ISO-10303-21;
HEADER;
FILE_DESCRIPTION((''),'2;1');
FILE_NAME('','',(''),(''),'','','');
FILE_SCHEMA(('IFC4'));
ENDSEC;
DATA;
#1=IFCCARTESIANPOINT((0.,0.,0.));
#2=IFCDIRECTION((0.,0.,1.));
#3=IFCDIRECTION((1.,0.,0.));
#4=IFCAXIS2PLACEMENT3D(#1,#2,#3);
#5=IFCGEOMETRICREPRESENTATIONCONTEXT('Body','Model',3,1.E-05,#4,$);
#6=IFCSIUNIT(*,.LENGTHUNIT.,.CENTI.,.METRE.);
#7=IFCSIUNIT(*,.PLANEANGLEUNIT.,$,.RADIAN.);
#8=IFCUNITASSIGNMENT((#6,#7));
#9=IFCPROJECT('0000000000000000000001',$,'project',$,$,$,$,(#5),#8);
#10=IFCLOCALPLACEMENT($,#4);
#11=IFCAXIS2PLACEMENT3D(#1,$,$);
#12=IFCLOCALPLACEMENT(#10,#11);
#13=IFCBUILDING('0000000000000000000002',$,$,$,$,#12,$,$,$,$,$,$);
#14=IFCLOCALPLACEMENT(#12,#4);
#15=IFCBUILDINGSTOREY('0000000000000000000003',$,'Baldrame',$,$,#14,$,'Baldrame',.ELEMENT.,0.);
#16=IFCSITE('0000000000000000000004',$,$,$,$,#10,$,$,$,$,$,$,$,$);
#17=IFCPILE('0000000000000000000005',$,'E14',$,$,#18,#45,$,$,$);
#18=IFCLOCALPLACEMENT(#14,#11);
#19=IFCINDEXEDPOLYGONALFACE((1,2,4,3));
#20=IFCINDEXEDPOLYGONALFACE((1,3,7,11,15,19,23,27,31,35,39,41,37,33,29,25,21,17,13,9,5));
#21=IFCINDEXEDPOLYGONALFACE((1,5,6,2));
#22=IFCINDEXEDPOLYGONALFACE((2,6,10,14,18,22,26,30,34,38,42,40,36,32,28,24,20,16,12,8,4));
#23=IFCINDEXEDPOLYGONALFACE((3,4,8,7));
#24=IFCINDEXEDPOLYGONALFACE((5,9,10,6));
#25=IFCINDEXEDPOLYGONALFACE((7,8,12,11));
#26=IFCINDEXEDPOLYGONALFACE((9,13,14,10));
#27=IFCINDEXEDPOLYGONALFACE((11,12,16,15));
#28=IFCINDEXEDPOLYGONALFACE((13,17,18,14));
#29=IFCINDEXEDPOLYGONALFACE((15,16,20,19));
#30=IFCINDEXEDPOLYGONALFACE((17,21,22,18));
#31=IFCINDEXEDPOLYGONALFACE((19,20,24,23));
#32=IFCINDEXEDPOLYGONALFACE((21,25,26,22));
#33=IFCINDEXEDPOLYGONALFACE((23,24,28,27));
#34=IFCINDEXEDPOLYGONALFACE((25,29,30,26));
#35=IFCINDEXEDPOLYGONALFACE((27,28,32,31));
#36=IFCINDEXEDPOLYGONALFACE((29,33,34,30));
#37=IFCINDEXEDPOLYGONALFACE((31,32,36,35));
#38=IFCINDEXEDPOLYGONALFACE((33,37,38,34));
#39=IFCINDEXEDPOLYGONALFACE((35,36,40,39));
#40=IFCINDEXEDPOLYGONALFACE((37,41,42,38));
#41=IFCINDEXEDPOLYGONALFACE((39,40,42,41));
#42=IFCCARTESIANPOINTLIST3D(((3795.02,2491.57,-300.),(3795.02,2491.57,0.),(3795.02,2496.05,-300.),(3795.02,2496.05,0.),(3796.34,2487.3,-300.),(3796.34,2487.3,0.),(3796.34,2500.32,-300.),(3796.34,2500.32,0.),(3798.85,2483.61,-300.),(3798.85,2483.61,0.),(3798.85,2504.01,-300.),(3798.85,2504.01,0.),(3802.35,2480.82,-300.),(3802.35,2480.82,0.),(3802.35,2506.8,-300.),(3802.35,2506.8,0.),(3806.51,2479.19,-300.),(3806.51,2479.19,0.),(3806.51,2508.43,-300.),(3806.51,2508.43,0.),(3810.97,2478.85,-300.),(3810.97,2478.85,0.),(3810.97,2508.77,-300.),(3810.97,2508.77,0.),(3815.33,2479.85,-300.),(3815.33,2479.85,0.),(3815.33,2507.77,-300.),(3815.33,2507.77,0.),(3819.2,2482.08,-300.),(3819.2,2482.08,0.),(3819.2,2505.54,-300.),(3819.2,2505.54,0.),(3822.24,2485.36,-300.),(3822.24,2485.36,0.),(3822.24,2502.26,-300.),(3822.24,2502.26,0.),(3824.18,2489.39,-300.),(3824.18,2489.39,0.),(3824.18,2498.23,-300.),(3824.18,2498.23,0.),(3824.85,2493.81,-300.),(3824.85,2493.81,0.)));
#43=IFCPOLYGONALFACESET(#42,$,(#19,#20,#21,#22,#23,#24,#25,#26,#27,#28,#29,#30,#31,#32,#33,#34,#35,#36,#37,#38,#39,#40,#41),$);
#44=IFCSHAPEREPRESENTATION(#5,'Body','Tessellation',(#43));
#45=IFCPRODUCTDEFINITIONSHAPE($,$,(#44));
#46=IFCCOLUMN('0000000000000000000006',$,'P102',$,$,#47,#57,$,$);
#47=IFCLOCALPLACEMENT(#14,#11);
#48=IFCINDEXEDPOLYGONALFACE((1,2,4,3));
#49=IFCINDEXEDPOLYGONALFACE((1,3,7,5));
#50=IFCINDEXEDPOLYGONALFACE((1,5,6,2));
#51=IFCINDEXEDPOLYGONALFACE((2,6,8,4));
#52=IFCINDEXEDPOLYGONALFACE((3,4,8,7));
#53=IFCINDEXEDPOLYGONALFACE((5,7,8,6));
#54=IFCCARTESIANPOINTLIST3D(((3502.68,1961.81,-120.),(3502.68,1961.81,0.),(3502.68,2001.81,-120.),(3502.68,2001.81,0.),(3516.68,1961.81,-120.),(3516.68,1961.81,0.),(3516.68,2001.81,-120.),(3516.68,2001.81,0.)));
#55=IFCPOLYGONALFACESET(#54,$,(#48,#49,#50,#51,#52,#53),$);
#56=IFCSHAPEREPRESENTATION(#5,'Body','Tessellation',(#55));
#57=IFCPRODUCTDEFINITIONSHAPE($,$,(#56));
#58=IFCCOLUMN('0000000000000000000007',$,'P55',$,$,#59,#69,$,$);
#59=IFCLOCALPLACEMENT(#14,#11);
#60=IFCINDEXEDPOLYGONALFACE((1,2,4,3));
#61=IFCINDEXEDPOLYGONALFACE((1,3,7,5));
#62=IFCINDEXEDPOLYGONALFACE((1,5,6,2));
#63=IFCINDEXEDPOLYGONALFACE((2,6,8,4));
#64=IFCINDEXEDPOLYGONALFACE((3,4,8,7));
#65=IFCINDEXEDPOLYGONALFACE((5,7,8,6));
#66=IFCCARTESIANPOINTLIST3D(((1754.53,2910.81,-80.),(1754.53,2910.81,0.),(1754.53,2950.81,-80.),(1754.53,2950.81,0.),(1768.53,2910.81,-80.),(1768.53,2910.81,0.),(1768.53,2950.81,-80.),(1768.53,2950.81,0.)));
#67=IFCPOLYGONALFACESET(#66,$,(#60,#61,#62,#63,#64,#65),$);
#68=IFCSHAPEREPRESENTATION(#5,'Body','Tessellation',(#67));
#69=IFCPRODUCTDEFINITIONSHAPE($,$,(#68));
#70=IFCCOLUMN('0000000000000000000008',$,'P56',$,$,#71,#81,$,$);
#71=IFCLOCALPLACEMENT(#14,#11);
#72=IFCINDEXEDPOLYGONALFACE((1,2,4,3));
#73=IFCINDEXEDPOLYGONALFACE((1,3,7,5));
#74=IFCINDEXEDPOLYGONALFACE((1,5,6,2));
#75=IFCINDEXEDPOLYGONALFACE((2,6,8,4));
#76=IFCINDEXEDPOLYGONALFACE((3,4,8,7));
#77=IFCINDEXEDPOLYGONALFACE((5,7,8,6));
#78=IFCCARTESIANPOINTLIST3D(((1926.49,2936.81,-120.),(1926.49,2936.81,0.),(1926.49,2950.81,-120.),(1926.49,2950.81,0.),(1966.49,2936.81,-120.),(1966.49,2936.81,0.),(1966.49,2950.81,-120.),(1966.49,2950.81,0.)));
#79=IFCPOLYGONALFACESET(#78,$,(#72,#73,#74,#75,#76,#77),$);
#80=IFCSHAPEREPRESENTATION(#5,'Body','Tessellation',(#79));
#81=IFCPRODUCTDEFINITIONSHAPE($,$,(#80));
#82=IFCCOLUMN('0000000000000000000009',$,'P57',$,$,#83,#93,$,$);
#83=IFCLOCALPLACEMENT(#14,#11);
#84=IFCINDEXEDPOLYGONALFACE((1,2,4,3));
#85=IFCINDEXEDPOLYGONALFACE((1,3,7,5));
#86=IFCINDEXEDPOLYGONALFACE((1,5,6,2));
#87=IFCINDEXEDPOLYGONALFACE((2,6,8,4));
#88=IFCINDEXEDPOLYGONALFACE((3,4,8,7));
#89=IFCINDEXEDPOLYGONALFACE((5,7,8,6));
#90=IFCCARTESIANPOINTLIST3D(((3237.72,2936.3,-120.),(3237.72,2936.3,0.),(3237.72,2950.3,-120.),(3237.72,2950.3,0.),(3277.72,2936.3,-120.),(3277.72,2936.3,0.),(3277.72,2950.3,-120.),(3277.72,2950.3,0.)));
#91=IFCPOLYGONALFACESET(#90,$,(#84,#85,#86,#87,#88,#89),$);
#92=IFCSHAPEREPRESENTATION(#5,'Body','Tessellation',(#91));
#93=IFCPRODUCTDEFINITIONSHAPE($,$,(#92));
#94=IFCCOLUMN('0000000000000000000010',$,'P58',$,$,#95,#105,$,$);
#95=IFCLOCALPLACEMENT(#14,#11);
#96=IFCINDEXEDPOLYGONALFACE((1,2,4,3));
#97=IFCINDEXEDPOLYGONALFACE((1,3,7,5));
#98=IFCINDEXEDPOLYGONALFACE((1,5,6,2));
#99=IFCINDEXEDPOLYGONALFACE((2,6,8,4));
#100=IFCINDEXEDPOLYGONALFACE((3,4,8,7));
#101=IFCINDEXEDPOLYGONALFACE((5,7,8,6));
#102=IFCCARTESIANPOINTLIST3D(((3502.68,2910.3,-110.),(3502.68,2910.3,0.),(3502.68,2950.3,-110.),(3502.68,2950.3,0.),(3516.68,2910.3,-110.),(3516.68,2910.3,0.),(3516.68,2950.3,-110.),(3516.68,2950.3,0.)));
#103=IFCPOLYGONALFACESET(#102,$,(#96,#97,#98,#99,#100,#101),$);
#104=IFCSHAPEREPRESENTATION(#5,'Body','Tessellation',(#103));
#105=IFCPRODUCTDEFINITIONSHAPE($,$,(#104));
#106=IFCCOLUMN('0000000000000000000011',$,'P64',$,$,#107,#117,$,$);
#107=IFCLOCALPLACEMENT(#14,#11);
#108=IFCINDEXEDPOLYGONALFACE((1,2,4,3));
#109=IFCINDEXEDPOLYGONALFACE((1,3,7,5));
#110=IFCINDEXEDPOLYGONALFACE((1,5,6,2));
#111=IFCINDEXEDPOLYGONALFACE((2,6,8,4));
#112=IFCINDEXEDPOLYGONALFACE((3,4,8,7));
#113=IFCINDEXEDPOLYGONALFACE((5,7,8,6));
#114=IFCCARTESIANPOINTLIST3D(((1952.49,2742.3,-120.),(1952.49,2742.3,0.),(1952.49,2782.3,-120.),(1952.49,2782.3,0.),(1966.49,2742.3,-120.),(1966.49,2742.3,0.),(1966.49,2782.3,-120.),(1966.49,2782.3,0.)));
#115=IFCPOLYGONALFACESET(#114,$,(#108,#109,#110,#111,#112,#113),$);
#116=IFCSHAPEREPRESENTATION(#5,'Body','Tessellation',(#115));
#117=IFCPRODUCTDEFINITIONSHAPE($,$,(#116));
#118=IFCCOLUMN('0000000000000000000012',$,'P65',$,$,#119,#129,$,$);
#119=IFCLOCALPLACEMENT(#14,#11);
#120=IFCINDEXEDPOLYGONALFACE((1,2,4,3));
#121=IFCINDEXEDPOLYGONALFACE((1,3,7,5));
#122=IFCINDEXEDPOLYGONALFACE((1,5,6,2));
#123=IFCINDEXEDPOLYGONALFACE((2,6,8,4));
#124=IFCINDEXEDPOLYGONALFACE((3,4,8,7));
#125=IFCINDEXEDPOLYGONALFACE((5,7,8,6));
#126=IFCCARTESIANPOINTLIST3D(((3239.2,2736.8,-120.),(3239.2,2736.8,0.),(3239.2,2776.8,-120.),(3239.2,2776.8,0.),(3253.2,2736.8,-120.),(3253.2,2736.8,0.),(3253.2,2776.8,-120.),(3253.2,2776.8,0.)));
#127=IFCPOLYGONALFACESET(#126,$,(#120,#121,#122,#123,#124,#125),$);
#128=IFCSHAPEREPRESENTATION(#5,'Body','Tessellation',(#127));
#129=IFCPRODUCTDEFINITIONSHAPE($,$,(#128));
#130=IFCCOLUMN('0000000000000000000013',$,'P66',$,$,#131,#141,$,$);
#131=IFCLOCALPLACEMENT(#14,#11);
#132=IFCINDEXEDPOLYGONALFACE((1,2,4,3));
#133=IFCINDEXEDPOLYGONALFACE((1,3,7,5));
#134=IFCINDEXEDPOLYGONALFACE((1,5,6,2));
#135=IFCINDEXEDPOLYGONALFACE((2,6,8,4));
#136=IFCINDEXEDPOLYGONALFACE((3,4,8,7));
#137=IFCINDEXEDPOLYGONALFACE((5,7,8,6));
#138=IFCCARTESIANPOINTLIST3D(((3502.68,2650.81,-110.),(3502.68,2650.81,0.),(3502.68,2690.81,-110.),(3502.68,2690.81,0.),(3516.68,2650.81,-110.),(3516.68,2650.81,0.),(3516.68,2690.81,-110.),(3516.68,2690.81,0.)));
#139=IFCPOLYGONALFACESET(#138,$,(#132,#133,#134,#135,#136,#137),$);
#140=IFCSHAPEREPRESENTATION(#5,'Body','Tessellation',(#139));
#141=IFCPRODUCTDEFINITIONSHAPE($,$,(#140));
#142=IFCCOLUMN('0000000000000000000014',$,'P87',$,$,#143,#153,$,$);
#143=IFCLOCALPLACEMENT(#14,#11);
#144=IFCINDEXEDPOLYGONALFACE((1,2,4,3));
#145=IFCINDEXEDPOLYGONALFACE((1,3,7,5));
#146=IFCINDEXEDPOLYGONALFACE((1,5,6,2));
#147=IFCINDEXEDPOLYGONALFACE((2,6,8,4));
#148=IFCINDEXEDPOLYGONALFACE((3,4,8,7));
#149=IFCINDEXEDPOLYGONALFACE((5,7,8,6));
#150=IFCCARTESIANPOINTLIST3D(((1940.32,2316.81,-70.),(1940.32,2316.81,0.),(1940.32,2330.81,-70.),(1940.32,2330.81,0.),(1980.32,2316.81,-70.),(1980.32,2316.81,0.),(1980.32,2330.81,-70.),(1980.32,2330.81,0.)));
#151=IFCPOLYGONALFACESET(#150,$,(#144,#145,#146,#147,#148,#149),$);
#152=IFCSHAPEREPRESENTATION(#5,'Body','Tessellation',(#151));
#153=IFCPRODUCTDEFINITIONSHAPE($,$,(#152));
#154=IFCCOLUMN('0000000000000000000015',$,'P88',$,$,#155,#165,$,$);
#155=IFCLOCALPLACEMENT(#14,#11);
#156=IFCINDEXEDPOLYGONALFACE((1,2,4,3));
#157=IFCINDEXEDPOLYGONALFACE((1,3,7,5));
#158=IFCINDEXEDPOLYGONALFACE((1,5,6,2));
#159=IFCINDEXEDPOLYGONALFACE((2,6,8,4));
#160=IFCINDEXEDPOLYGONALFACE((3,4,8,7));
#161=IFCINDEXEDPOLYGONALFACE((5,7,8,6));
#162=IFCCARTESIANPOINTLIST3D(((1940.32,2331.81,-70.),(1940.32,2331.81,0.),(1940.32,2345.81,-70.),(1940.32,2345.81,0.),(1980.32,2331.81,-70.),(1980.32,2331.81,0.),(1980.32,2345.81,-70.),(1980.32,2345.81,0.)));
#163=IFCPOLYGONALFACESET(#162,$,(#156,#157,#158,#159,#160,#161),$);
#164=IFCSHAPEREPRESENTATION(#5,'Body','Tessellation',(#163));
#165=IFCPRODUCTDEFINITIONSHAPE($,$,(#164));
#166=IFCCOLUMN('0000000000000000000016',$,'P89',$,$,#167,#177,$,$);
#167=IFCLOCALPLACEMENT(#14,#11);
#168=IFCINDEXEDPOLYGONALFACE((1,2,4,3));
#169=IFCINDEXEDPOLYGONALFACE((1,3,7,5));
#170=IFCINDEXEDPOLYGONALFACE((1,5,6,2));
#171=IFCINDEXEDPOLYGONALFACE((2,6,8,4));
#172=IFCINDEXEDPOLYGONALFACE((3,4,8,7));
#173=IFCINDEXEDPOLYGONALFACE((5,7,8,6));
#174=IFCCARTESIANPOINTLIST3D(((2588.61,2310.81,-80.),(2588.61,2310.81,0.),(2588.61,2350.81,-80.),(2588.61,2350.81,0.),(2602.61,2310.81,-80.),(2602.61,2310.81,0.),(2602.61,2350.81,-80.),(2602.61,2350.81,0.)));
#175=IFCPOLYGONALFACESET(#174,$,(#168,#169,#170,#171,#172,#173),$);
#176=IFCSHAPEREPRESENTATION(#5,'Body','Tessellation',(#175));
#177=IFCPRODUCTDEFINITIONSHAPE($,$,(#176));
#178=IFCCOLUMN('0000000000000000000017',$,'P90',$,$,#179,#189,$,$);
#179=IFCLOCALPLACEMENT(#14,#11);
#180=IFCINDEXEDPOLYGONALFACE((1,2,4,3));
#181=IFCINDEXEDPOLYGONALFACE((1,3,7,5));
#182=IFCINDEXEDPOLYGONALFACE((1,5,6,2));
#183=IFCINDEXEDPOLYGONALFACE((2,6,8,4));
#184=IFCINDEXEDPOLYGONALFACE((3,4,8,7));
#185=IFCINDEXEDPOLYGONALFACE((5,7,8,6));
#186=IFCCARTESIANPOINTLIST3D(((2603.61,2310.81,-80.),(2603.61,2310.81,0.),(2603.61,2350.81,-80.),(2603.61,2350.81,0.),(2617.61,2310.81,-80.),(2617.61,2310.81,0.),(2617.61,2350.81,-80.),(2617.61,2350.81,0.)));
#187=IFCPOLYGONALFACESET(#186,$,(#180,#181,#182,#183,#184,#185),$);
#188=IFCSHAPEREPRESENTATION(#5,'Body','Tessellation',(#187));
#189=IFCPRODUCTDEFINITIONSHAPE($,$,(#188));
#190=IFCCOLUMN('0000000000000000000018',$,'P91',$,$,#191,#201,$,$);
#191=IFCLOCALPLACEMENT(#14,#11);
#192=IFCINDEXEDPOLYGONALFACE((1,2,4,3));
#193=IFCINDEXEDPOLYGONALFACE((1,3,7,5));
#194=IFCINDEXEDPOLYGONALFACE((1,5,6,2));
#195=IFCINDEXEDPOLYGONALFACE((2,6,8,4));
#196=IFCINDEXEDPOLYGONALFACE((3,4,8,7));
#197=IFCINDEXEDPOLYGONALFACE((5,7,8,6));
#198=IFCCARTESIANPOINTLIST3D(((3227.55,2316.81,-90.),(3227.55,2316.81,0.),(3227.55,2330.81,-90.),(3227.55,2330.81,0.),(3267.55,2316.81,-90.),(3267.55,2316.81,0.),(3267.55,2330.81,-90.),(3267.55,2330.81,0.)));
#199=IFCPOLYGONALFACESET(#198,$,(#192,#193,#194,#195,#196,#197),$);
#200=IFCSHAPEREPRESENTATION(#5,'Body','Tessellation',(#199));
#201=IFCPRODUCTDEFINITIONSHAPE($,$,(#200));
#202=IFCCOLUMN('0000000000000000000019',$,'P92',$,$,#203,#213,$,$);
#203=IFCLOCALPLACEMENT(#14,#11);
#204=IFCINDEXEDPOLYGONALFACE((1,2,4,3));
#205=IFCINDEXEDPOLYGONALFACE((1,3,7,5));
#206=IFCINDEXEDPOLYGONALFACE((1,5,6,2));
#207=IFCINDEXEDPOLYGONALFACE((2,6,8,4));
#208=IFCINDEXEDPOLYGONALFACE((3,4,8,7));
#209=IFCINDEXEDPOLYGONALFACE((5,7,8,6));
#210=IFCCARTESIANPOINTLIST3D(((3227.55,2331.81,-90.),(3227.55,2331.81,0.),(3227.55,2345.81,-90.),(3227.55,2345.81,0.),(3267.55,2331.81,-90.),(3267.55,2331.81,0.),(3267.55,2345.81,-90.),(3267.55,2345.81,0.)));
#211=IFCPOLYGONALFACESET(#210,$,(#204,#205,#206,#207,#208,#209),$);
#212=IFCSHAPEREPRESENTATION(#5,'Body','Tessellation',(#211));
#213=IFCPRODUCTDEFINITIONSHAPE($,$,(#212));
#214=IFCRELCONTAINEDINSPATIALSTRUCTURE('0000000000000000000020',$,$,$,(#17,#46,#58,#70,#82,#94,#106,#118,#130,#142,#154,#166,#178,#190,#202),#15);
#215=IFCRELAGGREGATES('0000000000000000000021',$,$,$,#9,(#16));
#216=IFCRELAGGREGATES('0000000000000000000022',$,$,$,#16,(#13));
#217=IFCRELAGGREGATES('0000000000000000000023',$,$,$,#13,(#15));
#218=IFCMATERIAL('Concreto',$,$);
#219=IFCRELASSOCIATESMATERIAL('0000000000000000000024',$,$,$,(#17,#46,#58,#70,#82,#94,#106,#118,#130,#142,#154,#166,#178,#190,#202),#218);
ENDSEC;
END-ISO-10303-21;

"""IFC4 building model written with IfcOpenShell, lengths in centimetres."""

from ifc_helpers import new_model, si_unit, frame, origin, origin_with_axes, origin_2d_with_axis, place, context, project, spatial, rectangle, circle, extrude, material, element, save


model = new_model("IFC4")

# Units and contexts
model_context = context("Model", 3, precision=1e-05, world=origin_with_axes(), identifier="Body")
ifc_project = project(units=[si_unit("LENGTHUNIT", "METRE", prefix="CENTI"), si_unit("PLANEANGLEUNIT", "RADIAN")], contexts=[model_context])

# Site, building, storey
site_placement = place(None, origin_with_axes())
site = spatial("IfcSite", under=ifc_project, at=site_placement)
building_placement = place(site_placement, origin())
building = spatial("IfcBuilding", under=site, at=building_placement)
storey_placement = place(building_placement, origin_with_axes())
storey = spatial("IfcBuildingStorey", under=building, at=storey_placement, Name="Baldrame", LongName="Baldrame", CompositionType="ELEMENT", Elevation=0.0)

# Pile
ifc_material = material(Name="Concreto")
pile_placement = place(storey_placement, frame((3809.85, 2493.81, 0.0), z_axis=(0.0, 0.0, 1.0), x_axis=(1.0, 0.0, 0.0)))
element("IfcPile", 1, at=pile_placement, inside=storey, material=ifc_material, Name="E14", context=model_context, shape_type="SolidModel", body=[
    extrude(circle(Radius=15.0, at=origin_2d_with_axis()), frame((0.0, 0.0, -300.0), z_axis=(0.0, 0.0, 1.0), x_axis=(1.0, 0.0, 0.0)), (0.0, 0.0, 1.0), 300.0),
])

# Columns
column_1_placement = place(storey_placement, frame((3509.68, 1981.81, 0.0), z_axis=(0.0, 0.0, 1.0), x_axis=(1.0, 0.0, 0.0)))
element("IfcColumn", 2, at=column_1_placement, inside=storey, material=ifc_material, Name="P102", context=model_context, shape_type="SolidModel", body=[
    extrude(rectangle(XDim=14.0, YDim=40.0, at=origin_2d_with_axis()), frame((0.0, 0.0, -120.0), z_axis=(0.0, 0.0, 1.0), x_axis=(1.0, 0.0, 0.0)), (0.0, 0.0, 1.0), 120.0),
])
column_2_placement = place(storey_placement, frame((1761.53, 2930.81, 0.0), z_axis=(0.0, 0.0, 1.0), x_axis=(1.0, 0.0, 0.0)))
element("IfcColumn", 3, at=column_2_placement, inside=storey, material=ifc_material, Name="P55", context=model_context, shape_type="SolidModel", body=[
    extrude(rectangle(XDim=14.0, YDim=40.0, at=origin_2d_with_axis()), frame((0.0, 0.0, -80.0), z_axis=(0.0, 0.0, 1.0), x_axis=(1.0, 0.0, 0.0)), (0.0, 0.0, 1.0), 80.0),
])
for number, where, z_axis, x_axis, name in (
    (4, (1946.49, 2943.81, 0.0), (0.0, 0.0, 1.0), (1.0, 0.0, 0.0), "P56"),
    (5, (3257.72, 2943.3, 0.0), (0.0, 0.0, 1.0), (1.0, 0.0, 0.0), "P57"),
):
    element("IfcColumn", number, at=place(storey_placement, frame(where, z_axis=z_axis, x_axis=x_axis)), inside=storey, material=ifc_material, Name=name, context=model_context, shape_type="SolidModel", body=[
        extrude(rectangle(XDim=14.0, YDim=40.0, at=origin_2d_with_axis()), frame((0.0, 0.0, -120.0), z_axis=(0.0, 0.0, 1.0), x_axis=(0.0, -1.0, 0.0)), (0.0, 0.0, 1.0), 120.0),
    ])
column_3_placement = place(storey_placement, frame((3509.68, 2930.3, 0.0), z_axis=(0.0, 0.0, 1.0), x_axis=(1.0, 0.0, 0.0)))
element("IfcColumn", 6, at=column_3_placement, inside=storey, material=ifc_material, Name="P58", context=model_context, shape_type="SolidModel", body=[
    extrude(rectangle(XDim=14.0, YDim=40.0, at=origin_2d_with_axis()), frame((0.0, 0.0, -110.0), z_axis=(0.0, 0.0, 1.0), x_axis=(1.0, 0.0, 0.0)), (0.0, 0.0, 1.0), 110.0),
])
for number, where, z_axis, x_axis, name in (
    (7, (1959.49, 2762.3, 0.0), (0.0, 0.0, 1.0), (1.0, 0.0, 0.0), "P64"),
    (8, (3246.2, 2756.8, 0.0), (0.0, 0.0, 1.0), (1.0, 0.0, 0.0), "P65"),
):
    element("IfcColumn", number, at=place(storey_placement, frame(where, z_axis=z_axis, x_axis=x_axis)), inside=storey, material=ifc_material, Name=name, context=model_context, shape_type="SolidModel", body=[
        extrude(rectangle(XDim=14.0, YDim=40.0, at=origin_2d_with_axis()), frame((0.0, 0.0, -120.0), z_axis=(0.0, 0.0, 1.0), x_axis=(1.0, 0.0, 0.0)), (0.0, 0.0, 1.0), 120.0),
    ])
column_4_placement = place(storey_placement, frame((3509.68, 2670.81, 0.0), z_axis=(0.0, 0.0, 1.0), x_axis=(1.0, 0.0, 0.0)))
element("IfcColumn", 9, at=column_4_placement, inside=storey, material=ifc_material, Name="P66", context=model_context, shape_type="SolidModel", body=[
    extrude(rectangle(XDim=14.0, YDim=40.0, at=origin_2d_with_axis()), frame((0.0, 0.0, -110.0), z_axis=(0.0, 0.0, 1.0), x_axis=(1.0, 0.0, 0.0)), (0.0, 0.0, 1.0), 110.0),
])
for number, where, z_axis, x_axis, name in (
    (10, (1960.32, 2323.81, 0.0), (0.0, 0.0, 1.0), (1.0, 0.0, 0.0), "P87"),
    (11, (1960.32, 2338.81, 0.0), (0.0, 0.0, 1.0), (1.0, 0.0, 0.0), "P88"),
):
    element("IfcColumn", number, at=place(storey_placement, frame(where, z_axis=z_axis, x_axis=x_axis)), inside=storey, material=ifc_material, Name=name, context=model_context, shape_type="SolidModel", body=[
        extrude(rectangle(XDim=14.0, YDim=40.0, at=origin_2d_with_axis()), frame((0.0, 0.0, -70.0), z_axis=(0.0, 0.0, 1.0), x_axis=(0.0, -1.0, 0.0)), (0.0, 0.0, 1.0), 70.0),
    ])
for number, where, z_axis, x_axis, name in (
    (12, (2595.61, 2330.81, 0.0), (0.0, 0.0, 1.0), (1.0, 0.0, 0.0), "P89"),
    (13, (2610.61, 2330.81, 0.0), (0.0, 0.0, 1.0), (1.0, 0.0, 0.0), "P90"),
):
    element("IfcColumn", number, at=place(storey_placement, frame(where, z_axis=z_axis, x_axis=x_axis)), inside=storey, material=ifc_material, Name=name, context=model_context, shape_type="SolidModel", body=[
        extrude(rectangle(XDim=14.0, YDim=40.0, at=origin_2d_with_axis()), frame((0.0, 0.0, -80.0), z_axis=(0.0, 0.0, 1.0), x_axis=(1.0, 0.0, 0.0)), (0.0, 0.0, 1.0), 80.0),
    ])
for number, where, z_axis, x_axis, name in (
    (14, (3247.55, 2323.81, 0.0), (0.0, 0.0, 1.0), (1.0, 0.0, 0.0), "P91"),
    (15, (3247.55, 2338.81, 0.0), (0.0, 0.0, 1.0), (1.0, 0.0, 0.0), "P92"),
):
    element("IfcColumn", number, at=place(storey_placement, frame(where, z_axis=z_axis, x_axis=x_axis)), inside=storey, material=ifc_material, Name=name, context=model_context, shape_type="SolidModel", body=[
        extrude(rectangle(XDim=14.0, YDim=40.0, at=origin_2d_with_axis()), frame((0.0, 0.0, -90.0), z_axis=(0.0, 0.0, 1.0), x_axis=(0.0, -1.0, 0.0)), (0.0, 0.0, 1.0), 90.0),
    ])

save(model, "model.ifc")
